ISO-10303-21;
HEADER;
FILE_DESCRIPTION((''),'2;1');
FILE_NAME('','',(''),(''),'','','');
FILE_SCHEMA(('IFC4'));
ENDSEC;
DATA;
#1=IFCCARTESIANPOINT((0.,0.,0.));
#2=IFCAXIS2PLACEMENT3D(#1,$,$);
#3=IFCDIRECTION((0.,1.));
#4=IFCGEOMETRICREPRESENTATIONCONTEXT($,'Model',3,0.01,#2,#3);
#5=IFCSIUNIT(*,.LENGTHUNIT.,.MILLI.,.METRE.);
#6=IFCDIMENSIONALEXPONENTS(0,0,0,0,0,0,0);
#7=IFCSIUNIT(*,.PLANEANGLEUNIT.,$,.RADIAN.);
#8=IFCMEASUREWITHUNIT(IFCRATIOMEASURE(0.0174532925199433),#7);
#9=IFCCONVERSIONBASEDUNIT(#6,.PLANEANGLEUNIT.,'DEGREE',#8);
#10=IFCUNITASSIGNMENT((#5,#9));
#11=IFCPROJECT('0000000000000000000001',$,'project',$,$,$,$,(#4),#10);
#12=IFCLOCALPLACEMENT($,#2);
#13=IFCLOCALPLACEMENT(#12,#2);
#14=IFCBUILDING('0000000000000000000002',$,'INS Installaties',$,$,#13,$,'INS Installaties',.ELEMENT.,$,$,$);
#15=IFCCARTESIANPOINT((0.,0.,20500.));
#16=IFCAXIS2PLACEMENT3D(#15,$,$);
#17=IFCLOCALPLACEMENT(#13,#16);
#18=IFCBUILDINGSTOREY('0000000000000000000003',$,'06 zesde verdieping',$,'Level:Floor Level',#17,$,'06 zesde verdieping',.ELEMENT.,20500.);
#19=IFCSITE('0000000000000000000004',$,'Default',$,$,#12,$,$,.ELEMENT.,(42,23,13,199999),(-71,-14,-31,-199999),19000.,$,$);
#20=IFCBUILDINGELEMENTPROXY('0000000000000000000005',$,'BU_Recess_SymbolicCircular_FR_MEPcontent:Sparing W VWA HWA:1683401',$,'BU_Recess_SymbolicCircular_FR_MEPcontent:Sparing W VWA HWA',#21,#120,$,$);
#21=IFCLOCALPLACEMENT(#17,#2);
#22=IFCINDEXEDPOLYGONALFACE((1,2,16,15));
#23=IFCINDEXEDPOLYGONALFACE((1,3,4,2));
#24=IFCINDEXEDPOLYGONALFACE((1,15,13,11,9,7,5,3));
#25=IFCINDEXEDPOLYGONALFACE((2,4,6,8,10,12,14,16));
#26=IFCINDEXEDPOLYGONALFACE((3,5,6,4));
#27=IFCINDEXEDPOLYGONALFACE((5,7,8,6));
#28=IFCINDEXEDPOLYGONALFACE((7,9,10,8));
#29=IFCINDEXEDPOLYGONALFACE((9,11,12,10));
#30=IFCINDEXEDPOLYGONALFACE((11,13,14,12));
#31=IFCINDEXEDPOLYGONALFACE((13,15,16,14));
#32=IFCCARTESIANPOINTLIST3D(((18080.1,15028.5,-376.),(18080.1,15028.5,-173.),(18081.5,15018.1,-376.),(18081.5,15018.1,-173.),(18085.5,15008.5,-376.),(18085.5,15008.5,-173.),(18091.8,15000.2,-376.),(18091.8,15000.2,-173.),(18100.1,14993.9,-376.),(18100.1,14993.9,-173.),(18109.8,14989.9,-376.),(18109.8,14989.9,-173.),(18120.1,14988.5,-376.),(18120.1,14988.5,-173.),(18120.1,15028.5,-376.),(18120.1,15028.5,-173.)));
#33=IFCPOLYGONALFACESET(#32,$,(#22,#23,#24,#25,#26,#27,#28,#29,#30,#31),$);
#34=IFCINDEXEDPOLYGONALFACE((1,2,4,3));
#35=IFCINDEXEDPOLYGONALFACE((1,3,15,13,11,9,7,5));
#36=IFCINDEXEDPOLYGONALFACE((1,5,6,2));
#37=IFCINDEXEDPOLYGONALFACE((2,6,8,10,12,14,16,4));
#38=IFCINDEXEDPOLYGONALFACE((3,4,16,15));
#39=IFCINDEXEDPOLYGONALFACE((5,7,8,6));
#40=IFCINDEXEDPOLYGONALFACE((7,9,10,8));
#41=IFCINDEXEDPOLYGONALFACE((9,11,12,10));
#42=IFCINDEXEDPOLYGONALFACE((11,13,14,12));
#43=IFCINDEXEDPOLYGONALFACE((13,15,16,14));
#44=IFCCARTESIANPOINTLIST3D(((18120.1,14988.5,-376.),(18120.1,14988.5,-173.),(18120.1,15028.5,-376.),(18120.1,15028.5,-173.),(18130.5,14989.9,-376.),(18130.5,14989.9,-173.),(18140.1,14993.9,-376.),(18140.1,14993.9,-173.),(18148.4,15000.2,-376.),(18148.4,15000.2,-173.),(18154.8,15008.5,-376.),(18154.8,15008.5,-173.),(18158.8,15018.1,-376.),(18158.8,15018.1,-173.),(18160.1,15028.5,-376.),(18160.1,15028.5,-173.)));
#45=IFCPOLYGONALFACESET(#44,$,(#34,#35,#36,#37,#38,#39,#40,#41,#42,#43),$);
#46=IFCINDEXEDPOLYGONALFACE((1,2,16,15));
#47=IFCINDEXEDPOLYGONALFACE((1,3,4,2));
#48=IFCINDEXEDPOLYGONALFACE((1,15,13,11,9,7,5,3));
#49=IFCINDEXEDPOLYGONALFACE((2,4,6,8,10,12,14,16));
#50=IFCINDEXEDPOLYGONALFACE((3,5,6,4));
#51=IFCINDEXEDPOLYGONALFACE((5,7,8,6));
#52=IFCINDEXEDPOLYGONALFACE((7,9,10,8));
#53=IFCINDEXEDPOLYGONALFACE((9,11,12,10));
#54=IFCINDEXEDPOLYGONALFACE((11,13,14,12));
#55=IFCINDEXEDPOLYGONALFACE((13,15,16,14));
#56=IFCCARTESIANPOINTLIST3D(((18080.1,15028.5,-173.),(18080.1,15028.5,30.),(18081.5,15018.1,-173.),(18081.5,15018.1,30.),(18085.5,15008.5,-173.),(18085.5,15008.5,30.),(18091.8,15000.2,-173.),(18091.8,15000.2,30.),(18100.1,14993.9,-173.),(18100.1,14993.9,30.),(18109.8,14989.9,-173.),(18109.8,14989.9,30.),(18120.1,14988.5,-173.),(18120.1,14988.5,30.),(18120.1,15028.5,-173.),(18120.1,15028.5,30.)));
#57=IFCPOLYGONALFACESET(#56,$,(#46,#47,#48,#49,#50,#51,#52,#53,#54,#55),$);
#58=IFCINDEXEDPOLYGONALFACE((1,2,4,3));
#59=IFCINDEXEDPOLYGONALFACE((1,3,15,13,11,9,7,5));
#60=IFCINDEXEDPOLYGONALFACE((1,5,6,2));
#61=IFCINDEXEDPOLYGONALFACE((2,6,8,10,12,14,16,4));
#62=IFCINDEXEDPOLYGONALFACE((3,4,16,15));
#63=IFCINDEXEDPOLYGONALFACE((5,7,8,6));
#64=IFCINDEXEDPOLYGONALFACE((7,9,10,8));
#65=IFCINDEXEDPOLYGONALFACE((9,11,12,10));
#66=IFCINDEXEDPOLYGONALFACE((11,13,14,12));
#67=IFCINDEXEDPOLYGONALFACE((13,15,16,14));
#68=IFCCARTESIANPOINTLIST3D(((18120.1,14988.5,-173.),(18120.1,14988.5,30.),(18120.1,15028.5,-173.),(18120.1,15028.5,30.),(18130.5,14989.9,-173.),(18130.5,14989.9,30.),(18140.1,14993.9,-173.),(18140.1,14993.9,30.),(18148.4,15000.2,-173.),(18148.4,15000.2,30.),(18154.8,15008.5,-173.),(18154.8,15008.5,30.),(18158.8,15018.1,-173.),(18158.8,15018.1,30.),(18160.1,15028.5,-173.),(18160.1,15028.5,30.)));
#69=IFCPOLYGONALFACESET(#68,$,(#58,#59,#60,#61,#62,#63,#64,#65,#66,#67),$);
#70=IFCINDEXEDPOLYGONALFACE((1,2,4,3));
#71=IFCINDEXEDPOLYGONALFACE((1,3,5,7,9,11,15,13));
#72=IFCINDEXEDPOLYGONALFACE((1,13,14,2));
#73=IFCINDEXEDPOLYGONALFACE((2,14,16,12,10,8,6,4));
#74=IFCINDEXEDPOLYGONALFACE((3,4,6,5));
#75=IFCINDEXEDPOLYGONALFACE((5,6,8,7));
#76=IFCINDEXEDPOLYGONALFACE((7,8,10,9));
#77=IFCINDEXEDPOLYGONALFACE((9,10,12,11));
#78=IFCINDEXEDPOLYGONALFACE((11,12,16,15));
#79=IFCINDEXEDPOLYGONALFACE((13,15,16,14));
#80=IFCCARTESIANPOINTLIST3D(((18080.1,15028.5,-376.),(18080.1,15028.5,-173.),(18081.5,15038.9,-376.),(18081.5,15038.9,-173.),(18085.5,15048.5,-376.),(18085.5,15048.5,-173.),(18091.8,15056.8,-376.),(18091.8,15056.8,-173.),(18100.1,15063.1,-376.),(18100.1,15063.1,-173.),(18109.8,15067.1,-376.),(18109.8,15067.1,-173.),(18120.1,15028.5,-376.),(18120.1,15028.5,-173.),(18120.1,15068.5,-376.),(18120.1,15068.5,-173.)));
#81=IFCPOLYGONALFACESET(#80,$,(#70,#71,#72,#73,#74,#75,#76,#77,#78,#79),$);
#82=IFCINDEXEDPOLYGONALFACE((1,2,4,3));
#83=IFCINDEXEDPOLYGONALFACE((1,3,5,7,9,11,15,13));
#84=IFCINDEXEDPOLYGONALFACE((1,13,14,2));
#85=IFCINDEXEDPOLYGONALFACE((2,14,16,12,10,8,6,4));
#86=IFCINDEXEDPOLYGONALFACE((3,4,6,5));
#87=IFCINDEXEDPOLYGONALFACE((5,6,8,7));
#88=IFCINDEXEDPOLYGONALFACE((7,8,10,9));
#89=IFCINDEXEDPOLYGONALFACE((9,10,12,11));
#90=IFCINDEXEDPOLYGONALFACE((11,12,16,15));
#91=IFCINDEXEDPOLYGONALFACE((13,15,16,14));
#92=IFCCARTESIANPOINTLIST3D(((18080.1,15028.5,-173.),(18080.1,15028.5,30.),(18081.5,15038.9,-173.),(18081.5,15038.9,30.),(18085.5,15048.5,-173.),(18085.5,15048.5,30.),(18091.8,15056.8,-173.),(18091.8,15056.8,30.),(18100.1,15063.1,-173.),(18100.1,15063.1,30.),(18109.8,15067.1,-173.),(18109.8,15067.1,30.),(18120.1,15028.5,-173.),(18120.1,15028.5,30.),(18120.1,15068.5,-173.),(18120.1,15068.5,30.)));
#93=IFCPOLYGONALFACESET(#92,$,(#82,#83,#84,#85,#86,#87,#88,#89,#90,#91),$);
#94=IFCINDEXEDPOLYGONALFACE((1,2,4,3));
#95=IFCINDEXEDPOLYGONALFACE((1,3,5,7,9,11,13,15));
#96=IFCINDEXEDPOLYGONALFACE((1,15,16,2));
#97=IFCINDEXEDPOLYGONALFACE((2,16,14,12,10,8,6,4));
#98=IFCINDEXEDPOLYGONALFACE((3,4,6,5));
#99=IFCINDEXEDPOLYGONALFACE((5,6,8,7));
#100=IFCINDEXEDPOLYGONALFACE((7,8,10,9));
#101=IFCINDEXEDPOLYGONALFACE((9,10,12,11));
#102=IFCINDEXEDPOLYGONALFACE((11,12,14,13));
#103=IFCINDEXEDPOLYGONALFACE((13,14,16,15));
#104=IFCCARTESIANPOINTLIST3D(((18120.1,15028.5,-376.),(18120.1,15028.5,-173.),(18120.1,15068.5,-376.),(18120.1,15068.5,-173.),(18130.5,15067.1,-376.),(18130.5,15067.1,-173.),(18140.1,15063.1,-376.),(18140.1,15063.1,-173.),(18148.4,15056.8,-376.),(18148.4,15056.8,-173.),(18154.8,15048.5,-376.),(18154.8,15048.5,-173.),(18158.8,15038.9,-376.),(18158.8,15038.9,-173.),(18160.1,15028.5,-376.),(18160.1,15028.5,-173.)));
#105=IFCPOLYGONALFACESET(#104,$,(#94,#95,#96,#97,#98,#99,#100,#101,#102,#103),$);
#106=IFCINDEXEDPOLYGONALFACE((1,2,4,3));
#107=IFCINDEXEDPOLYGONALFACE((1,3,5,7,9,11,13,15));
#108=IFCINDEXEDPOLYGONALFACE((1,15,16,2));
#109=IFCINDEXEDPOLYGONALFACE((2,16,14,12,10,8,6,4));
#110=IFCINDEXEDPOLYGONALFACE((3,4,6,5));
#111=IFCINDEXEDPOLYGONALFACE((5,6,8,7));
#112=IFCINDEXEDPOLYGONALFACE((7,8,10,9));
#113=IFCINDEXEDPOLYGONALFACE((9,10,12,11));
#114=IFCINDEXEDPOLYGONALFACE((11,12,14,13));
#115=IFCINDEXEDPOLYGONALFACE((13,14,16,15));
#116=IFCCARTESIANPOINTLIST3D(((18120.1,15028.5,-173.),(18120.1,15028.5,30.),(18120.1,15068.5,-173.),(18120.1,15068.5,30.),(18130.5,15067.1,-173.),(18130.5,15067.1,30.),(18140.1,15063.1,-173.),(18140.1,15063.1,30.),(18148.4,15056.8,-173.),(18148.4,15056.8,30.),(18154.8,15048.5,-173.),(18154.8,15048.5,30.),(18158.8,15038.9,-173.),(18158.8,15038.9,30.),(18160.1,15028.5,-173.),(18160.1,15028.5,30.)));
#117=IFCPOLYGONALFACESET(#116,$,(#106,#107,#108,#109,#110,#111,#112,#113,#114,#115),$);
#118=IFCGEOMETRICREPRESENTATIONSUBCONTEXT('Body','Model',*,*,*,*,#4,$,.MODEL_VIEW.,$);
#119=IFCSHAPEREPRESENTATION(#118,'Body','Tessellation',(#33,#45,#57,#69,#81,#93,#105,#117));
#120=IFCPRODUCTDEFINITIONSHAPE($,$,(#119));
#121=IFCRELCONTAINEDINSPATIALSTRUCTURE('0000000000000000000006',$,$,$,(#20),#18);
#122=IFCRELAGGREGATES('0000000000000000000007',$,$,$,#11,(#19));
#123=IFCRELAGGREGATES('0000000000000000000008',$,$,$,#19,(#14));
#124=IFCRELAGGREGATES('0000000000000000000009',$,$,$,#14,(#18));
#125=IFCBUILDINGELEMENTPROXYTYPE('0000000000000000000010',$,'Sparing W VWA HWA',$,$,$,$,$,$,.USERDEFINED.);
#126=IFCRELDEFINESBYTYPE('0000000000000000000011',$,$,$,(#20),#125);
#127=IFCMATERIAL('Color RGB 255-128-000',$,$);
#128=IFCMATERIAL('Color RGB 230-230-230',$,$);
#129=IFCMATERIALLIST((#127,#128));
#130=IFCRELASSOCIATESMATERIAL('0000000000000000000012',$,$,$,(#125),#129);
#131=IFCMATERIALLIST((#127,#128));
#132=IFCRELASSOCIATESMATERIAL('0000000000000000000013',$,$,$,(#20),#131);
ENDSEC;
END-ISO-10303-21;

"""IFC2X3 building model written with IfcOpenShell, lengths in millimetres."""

from ifc_helpers import new_model, entity, si_unit, converted_unit, direction, frame, frame_2d, origin, place, context, subcontext, project, spatial, polyline, circle_curve, parameter, trimmed, segment, composite_curve, outline, extrude, source, transform, mapped, material, material_list, type_object, type_shapes, element, save


model = new_model("IFC2X3")

# Units and contexts
model_context = context("Model", 3, precision=0.01, world=origin(), true_north=direction((0.0, 1.0)))
body_context = subcontext(model_context, "Body", "Model", "MODEL_VIEW")
ifc_project = project(units=[si_unit("LENGTHUNIT", "METRE", prefix="MILLI"), converted_unit("PLANEANGLEUNIT", "DEGREE", entity("IfcRatioMeasure", 0.0174532925199433), si_unit("PLANEANGLEUNIT", "RADIAN"), dimensions=[0, 0, 0, 0, 0, 0, 0])], contexts=[model_context])

# Site, building, storey
site_placement = place(None, origin())
site = spatial("IfcSite", under=ifc_project, at=site_placement, Name="Default", CompositionType="ELEMENT", RefLatitude=(42, 23, 13, 199999), RefLongitude=(-71, -14, -31, -199999), RefElevation=19000.0)
building_placement = place(site_placement, origin())
building = spatial("IfcBuilding", under=site, at=building_placement, Name="INS Installaties", LongName="INS Installaties", CompositionType="ELEMENT")
storey_placement = place(building_placement, frame((0.0, 0.0, 20500.0)))
storey = spatial("IfcBuildingStorey", under=building, at=storey_placement, Name="06 zesde verdieping", ObjectType="Level:Floor Level", LongName="06 zesde verdieping", CompositionType="ELEMENT", Elevation=20500.0)

# Building element proxy
ifc_material_1 = material(Name="Color RGB 255-128-000")
ifc_material_2 = material(Name="Color RGB 230-230-230")
ifc_material_list_1 = material_list([ifc_material_1, ifc_material_2])
building_element_proxy_type_1 = type_object("IfcBuildingElementProxyType", Name="Sparing W VWA HWA", PredefinedType="USERDEFINED", material=ifc_material_list_1)
shared_shape_1 = source(origin(), body_context, "Body", "SweptSolid", [
    extrude(outline(composite_curve([segment(trimmed(circle_curve(frame_2d((13.3, 13.3), x_axis=(1.0, 0.0)), 40.0), [parameter(180.0)], [parameter(270.0)], True, "PARAMETER"), True, "CONTINUOUS"), segment(polyline([(13.3, -26.7), (13.3, 13.3)]), True, "CONTINUOUS"), segment(polyline([(13.3, 13.3), (-26.7, 13.3)]), True, "CONTINUOUS")], self_intersect=False)), frame((13.3, 13.3, -403.0), z_axis=(0.0, 0.0, 1.0), x_axis=(-1.0, 0.0, 0.0)), (0.0, 0.0, 1.0), 203.0),
    extrude(outline(composite_curve([segment(polyline([(-26.7, -13.3), (13.3, -13.3)]), True, "CONTINUOUS"), segment(polyline([(13.3, -13.3), (13.3, 26.7)]), True, "CONTINUOUS"), segment(trimmed(circle_curve(frame_2d((13.3, -13.3), x_axis=(1.0, 0.0)), 40.0), [parameter(90.0)], [parameter(180.0)], True, "PARAMETER"), True, "CONTINUOUS")], self_intersect=False)), frame((-13.3, 13.3, -403.0)), (0.0, 0.0, 1.0), 203.0),
    extrude(outline(composite_curve([segment(trimmed(circle_curve(frame_2d((13.3, 13.3), x_axis=(1.0, 0.0)), 40.0), [parameter(180.0)], [parameter(270.0)], True, "PARAMETER"), True, "CONTINUOUS"), segment(polyline([(13.3, -26.7), (13.3, 13.3)]), True, "CONTINUOUS"), segment(polyline([(13.3, 13.3), (-26.7, 13.3)]), True, "CONTINUOUS")], self_intersect=False)), frame((13.3, 13.3, -200.0), z_axis=(0.0, 0.0, 1.0), x_axis=(-1.0, 0.0, 0.0)), (0.0, 0.0, 1.0), 203.0),
    extrude(outline(composite_curve([segment(polyline([(-26.7, -13.3), (13.3, -13.3)]), True, "CONTINUOUS"), segment(polyline([(13.3, -13.3), (13.3, 26.7)]), True, "CONTINUOUS"), segment(trimmed(circle_curve(frame_2d((13.3, -13.3), x_axis=(1.0, 0.0)), 40.0), [parameter(90.0)], [parameter(180.0)], True, "PARAMETER"), True, "CONTINUOUS")], self_intersect=False)), frame((-13.3, 13.3, -200.0)), (0.0, 0.0, 1.0), 203.0),
    extrude(outline(composite_curve([segment(polyline([(-26.7, -13.3), (13.3, -13.3)]), True, "CONTINUOUS"), segment(polyline([(13.3, -13.3), (13.3, 26.7)]), True, "CONTINUOUS"), segment(trimmed(circle_curve(frame_2d((13.3, -13.3), x_axis=(1.0, 0.0)), 40.0), [parameter(90.0)], [parameter(180.0)], True, "PARAMETER"), True, "CONTINUOUS")], self_intersect=False)), frame((13.3, -13.3, -403.0), z_axis=(0.0, 0.0, 1.0), x_axis=(-1.0, 0.0, 0.0)), (0.0, 0.0, 1.0), 203.0),
    extrude(outline(composite_curve([segment(polyline([(-26.7, -13.3), (13.3, -13.3)]), True, "CONTINUOUS"), segment(polyline([(13.3, -13.3), (13.3, 26.7)]), True, "CONTINUOUS"), segment(trimmed(circle_curve(frame_2d((13.3, -13.3), x_axis=(1.0, 0.0)), 40.0), [parameter(90.0)], [parameter(180.0)], True, "PARAMETER"), True, "CONTINUOUS")], self_intersect=False)), frame((13.3, -13.3, -200.0), z_axis=(0.0, 0.0, 1.0), x_axis=(-1.0, 0.0, 0.0)), (0.0, 0.0, 1.0), 203.0),
    extrude(outline(composite_curve([segment(trimmed(circle_curve(frame_2d((13.3, 13.3), x_axis=(1.0, 0.0)), 40.0), [parameter(180.0)], [parameter(270.0)], True, "PARAMETER"), True, "CONTINUOUS"), segment(polyline([(13.3, -26.7), (13.3, 13.3)]), True, "CONTINUOUS"), segment(polyline([(13.3, 13.3), (-26.7, 13.3)]), True, "CONTINUOUS")], self_intersect=False)), frame((-13.3, -13.3, -403.0)), (0.0, 0.0, 1.0), 203.0),
    extrude(outline(composite_curve([segment(trimmed(circle_curve(frame_2d((13.3, 13.3), x_axis=(1.0, 0.0)), 40.0), [parameter(180.0)], [parameter(270.0)], True, "PARAMETER"), True, "CONTINUOUS"), segment(polyline([(13.3, -26.7), (13.3, 13.3)]), True, "CONTINUOUS"), segment(polyline([(13.3, 13.3), (-26.7, 13.3)]), True, "CONTINUOUS")], self_intersect=False)), frame((-13.3, -13.3, -200.0)), (0.0, 0.0, 1.0), 203.0),
])
type_shapes(building_element_proxy_type_1, [shared_shape_1])
ifc_material_list_2 = material_list([ifc_material_1, ifc_material_2])
proxy_1_placement = place(storey_placement, frame((18120.1, 15028.5, 27.0), z_axis=(0.0, 0.0, 1.0), x_axis=(-1.0, 0.0, 0.0)))
element("IfcBuildingElementProxy", 1, at=proxy_1_placement, inside=storey, type_object=building_element_proxy_type_1, material=ifc_material_list_2, Name="BU_Recess_SymbolicCircular_FR_MEPcontent:Sparing W VWA HWA:1683401", ObjectType="BU_Recess_SymbolicCircular_FR_MEPcontent:Sparing W VWA HWA", context=body_context, shape_type="MappedRepresentation", body=[
    mapped(shared_shape_1, transform((0.0, 0.0, 0.0), scale=1.0)),
])

save(model, "model.ifc")
